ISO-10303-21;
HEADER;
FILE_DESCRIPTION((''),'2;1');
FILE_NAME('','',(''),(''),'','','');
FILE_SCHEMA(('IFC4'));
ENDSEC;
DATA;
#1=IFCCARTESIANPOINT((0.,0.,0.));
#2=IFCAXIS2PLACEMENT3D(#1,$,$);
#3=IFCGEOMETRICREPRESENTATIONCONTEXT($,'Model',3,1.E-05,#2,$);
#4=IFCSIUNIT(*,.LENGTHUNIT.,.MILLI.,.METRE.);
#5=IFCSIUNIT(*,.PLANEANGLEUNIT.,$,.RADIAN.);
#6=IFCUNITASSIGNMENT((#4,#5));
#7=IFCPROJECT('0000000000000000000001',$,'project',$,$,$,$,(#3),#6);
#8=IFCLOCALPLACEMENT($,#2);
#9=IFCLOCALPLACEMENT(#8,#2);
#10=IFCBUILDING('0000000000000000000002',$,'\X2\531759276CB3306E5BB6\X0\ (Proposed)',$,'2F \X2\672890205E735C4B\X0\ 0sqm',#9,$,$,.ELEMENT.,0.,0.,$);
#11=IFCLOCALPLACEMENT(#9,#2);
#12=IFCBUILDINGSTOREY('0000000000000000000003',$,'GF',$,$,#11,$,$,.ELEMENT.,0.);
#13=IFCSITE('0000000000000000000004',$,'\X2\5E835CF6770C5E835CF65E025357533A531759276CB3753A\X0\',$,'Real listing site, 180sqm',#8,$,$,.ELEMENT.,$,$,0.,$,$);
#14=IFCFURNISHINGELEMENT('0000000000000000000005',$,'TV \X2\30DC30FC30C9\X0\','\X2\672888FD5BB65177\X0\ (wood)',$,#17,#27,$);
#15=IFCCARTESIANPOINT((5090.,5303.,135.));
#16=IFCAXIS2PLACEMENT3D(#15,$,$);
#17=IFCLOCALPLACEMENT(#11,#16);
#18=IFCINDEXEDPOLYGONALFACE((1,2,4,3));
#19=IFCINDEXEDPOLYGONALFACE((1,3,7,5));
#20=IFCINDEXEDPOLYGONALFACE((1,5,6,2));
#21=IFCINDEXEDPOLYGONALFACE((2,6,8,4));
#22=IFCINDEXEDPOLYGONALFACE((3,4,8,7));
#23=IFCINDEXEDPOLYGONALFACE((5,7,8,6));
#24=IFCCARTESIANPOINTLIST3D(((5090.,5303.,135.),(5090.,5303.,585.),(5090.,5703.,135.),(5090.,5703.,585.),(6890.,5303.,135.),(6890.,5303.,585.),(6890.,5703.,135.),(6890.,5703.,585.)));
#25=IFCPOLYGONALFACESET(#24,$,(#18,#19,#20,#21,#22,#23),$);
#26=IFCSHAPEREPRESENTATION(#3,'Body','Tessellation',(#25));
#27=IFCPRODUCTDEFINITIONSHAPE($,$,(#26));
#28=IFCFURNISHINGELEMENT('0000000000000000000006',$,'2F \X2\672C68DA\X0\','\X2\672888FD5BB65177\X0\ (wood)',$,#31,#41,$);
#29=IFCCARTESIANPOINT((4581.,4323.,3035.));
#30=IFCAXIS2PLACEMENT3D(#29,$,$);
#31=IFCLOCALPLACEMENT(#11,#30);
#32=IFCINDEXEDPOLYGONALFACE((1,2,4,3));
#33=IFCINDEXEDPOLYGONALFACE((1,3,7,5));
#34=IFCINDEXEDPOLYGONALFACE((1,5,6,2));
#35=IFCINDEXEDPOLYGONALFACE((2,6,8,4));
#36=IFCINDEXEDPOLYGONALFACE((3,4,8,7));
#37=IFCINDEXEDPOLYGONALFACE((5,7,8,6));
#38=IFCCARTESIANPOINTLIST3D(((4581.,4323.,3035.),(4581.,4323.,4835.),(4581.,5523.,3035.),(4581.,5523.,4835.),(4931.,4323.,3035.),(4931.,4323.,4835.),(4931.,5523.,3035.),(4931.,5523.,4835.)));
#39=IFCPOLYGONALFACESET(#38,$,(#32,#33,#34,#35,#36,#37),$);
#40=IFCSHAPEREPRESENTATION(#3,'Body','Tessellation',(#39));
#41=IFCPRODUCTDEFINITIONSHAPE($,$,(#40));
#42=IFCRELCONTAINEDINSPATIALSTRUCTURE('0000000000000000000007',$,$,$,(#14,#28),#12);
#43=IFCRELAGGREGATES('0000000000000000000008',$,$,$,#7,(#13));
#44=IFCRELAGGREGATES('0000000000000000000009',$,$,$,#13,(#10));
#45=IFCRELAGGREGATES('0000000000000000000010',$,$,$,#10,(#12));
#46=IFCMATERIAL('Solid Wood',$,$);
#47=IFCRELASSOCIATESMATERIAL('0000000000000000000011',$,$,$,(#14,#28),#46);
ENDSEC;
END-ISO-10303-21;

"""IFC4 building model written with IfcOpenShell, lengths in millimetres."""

from ifc_helpers import new_model, si_unit, frame, frame_2d, origin, place, context, project, spatial, rectangle, extrude, material, element, save


model = new_model("IFC4")

# Units and contexts
model_context = context("Model", 3, precision=1e-05, world=origin())
ifc_project = project(units=[si_unit("LENGTHUNIT", "METRE", prefix="MILLI"), si_unit("PLANEANGLEUNIT", "RADIAN")], contexts=[model_context])

# Site, building, storey
site_placement = place(None, origin())
site = spatial("IfcSite", under=ifc_project, at=site_placement, Name="広島県広島市南区北大河町", ObjectType="Real listing site, 180sqm", CompositionType="ELEMENT", RefElevation=0.0)
building_placement = place(site_placement, origin())
building = spatial("IfcBuilding", under=site, at=building_placement, Name="北大河の家 (Proposed)", ObjectType="2F 木造平屋 0sqm", CompositionType="ELEMENT", ElevationOfRefHeight=0.0, ElevationOfTerrain=0.0)
storey_placement = place(building_placement, origin())
storey = spatial("IfcBuildingStorey", under=building, at=storey_placement, Name="GF", CompositionType="ELEMENT", Elevation=0.0)

# Shared definitions
ifc_material_1 = material(Name="Solid Wood")

# Furnishing elements
furnishing_1_placement = place(storey_placement, frame((5090.0, 5303.0, 135.0)))
element("IfcFurnishingElement", 1, at=furnishing_1_placement, inside=storey, material=ifc_material_1, Name="TV ボード", Description="木製家具 (wood)", context=model_context, shape_type="SweptSolid", body=[
    extrude(rectangle(XDim=1800.0, YDim=400.0, at=frame_2d((900.0, 200.0))), frame((5090.0, 5303.0, 135.0)), (0.0, 0.0, 1.0), 450.0),
])
furnishing_2_placement = place(storey_placement, frame((4581.0, 4323.0, 3035.0)))
element("IfcFurnishingElement", 2, at=furnishing_2_placement, inside=storey, material=ifc_material_1, Name="2F 本棚", Description="木製家具 (wood)", context=model_context, shape_type="SweptSolid", body=[
    extrude(rectangle(XDim=350.0, YDim=1200.0, at=frame_2d((175.0, 600.0))), frame((4581.0, 4323.0, 3035.0)), (0.0, 0.0, 1.0), 1800.0),
])

save(model, "model.ifc")
